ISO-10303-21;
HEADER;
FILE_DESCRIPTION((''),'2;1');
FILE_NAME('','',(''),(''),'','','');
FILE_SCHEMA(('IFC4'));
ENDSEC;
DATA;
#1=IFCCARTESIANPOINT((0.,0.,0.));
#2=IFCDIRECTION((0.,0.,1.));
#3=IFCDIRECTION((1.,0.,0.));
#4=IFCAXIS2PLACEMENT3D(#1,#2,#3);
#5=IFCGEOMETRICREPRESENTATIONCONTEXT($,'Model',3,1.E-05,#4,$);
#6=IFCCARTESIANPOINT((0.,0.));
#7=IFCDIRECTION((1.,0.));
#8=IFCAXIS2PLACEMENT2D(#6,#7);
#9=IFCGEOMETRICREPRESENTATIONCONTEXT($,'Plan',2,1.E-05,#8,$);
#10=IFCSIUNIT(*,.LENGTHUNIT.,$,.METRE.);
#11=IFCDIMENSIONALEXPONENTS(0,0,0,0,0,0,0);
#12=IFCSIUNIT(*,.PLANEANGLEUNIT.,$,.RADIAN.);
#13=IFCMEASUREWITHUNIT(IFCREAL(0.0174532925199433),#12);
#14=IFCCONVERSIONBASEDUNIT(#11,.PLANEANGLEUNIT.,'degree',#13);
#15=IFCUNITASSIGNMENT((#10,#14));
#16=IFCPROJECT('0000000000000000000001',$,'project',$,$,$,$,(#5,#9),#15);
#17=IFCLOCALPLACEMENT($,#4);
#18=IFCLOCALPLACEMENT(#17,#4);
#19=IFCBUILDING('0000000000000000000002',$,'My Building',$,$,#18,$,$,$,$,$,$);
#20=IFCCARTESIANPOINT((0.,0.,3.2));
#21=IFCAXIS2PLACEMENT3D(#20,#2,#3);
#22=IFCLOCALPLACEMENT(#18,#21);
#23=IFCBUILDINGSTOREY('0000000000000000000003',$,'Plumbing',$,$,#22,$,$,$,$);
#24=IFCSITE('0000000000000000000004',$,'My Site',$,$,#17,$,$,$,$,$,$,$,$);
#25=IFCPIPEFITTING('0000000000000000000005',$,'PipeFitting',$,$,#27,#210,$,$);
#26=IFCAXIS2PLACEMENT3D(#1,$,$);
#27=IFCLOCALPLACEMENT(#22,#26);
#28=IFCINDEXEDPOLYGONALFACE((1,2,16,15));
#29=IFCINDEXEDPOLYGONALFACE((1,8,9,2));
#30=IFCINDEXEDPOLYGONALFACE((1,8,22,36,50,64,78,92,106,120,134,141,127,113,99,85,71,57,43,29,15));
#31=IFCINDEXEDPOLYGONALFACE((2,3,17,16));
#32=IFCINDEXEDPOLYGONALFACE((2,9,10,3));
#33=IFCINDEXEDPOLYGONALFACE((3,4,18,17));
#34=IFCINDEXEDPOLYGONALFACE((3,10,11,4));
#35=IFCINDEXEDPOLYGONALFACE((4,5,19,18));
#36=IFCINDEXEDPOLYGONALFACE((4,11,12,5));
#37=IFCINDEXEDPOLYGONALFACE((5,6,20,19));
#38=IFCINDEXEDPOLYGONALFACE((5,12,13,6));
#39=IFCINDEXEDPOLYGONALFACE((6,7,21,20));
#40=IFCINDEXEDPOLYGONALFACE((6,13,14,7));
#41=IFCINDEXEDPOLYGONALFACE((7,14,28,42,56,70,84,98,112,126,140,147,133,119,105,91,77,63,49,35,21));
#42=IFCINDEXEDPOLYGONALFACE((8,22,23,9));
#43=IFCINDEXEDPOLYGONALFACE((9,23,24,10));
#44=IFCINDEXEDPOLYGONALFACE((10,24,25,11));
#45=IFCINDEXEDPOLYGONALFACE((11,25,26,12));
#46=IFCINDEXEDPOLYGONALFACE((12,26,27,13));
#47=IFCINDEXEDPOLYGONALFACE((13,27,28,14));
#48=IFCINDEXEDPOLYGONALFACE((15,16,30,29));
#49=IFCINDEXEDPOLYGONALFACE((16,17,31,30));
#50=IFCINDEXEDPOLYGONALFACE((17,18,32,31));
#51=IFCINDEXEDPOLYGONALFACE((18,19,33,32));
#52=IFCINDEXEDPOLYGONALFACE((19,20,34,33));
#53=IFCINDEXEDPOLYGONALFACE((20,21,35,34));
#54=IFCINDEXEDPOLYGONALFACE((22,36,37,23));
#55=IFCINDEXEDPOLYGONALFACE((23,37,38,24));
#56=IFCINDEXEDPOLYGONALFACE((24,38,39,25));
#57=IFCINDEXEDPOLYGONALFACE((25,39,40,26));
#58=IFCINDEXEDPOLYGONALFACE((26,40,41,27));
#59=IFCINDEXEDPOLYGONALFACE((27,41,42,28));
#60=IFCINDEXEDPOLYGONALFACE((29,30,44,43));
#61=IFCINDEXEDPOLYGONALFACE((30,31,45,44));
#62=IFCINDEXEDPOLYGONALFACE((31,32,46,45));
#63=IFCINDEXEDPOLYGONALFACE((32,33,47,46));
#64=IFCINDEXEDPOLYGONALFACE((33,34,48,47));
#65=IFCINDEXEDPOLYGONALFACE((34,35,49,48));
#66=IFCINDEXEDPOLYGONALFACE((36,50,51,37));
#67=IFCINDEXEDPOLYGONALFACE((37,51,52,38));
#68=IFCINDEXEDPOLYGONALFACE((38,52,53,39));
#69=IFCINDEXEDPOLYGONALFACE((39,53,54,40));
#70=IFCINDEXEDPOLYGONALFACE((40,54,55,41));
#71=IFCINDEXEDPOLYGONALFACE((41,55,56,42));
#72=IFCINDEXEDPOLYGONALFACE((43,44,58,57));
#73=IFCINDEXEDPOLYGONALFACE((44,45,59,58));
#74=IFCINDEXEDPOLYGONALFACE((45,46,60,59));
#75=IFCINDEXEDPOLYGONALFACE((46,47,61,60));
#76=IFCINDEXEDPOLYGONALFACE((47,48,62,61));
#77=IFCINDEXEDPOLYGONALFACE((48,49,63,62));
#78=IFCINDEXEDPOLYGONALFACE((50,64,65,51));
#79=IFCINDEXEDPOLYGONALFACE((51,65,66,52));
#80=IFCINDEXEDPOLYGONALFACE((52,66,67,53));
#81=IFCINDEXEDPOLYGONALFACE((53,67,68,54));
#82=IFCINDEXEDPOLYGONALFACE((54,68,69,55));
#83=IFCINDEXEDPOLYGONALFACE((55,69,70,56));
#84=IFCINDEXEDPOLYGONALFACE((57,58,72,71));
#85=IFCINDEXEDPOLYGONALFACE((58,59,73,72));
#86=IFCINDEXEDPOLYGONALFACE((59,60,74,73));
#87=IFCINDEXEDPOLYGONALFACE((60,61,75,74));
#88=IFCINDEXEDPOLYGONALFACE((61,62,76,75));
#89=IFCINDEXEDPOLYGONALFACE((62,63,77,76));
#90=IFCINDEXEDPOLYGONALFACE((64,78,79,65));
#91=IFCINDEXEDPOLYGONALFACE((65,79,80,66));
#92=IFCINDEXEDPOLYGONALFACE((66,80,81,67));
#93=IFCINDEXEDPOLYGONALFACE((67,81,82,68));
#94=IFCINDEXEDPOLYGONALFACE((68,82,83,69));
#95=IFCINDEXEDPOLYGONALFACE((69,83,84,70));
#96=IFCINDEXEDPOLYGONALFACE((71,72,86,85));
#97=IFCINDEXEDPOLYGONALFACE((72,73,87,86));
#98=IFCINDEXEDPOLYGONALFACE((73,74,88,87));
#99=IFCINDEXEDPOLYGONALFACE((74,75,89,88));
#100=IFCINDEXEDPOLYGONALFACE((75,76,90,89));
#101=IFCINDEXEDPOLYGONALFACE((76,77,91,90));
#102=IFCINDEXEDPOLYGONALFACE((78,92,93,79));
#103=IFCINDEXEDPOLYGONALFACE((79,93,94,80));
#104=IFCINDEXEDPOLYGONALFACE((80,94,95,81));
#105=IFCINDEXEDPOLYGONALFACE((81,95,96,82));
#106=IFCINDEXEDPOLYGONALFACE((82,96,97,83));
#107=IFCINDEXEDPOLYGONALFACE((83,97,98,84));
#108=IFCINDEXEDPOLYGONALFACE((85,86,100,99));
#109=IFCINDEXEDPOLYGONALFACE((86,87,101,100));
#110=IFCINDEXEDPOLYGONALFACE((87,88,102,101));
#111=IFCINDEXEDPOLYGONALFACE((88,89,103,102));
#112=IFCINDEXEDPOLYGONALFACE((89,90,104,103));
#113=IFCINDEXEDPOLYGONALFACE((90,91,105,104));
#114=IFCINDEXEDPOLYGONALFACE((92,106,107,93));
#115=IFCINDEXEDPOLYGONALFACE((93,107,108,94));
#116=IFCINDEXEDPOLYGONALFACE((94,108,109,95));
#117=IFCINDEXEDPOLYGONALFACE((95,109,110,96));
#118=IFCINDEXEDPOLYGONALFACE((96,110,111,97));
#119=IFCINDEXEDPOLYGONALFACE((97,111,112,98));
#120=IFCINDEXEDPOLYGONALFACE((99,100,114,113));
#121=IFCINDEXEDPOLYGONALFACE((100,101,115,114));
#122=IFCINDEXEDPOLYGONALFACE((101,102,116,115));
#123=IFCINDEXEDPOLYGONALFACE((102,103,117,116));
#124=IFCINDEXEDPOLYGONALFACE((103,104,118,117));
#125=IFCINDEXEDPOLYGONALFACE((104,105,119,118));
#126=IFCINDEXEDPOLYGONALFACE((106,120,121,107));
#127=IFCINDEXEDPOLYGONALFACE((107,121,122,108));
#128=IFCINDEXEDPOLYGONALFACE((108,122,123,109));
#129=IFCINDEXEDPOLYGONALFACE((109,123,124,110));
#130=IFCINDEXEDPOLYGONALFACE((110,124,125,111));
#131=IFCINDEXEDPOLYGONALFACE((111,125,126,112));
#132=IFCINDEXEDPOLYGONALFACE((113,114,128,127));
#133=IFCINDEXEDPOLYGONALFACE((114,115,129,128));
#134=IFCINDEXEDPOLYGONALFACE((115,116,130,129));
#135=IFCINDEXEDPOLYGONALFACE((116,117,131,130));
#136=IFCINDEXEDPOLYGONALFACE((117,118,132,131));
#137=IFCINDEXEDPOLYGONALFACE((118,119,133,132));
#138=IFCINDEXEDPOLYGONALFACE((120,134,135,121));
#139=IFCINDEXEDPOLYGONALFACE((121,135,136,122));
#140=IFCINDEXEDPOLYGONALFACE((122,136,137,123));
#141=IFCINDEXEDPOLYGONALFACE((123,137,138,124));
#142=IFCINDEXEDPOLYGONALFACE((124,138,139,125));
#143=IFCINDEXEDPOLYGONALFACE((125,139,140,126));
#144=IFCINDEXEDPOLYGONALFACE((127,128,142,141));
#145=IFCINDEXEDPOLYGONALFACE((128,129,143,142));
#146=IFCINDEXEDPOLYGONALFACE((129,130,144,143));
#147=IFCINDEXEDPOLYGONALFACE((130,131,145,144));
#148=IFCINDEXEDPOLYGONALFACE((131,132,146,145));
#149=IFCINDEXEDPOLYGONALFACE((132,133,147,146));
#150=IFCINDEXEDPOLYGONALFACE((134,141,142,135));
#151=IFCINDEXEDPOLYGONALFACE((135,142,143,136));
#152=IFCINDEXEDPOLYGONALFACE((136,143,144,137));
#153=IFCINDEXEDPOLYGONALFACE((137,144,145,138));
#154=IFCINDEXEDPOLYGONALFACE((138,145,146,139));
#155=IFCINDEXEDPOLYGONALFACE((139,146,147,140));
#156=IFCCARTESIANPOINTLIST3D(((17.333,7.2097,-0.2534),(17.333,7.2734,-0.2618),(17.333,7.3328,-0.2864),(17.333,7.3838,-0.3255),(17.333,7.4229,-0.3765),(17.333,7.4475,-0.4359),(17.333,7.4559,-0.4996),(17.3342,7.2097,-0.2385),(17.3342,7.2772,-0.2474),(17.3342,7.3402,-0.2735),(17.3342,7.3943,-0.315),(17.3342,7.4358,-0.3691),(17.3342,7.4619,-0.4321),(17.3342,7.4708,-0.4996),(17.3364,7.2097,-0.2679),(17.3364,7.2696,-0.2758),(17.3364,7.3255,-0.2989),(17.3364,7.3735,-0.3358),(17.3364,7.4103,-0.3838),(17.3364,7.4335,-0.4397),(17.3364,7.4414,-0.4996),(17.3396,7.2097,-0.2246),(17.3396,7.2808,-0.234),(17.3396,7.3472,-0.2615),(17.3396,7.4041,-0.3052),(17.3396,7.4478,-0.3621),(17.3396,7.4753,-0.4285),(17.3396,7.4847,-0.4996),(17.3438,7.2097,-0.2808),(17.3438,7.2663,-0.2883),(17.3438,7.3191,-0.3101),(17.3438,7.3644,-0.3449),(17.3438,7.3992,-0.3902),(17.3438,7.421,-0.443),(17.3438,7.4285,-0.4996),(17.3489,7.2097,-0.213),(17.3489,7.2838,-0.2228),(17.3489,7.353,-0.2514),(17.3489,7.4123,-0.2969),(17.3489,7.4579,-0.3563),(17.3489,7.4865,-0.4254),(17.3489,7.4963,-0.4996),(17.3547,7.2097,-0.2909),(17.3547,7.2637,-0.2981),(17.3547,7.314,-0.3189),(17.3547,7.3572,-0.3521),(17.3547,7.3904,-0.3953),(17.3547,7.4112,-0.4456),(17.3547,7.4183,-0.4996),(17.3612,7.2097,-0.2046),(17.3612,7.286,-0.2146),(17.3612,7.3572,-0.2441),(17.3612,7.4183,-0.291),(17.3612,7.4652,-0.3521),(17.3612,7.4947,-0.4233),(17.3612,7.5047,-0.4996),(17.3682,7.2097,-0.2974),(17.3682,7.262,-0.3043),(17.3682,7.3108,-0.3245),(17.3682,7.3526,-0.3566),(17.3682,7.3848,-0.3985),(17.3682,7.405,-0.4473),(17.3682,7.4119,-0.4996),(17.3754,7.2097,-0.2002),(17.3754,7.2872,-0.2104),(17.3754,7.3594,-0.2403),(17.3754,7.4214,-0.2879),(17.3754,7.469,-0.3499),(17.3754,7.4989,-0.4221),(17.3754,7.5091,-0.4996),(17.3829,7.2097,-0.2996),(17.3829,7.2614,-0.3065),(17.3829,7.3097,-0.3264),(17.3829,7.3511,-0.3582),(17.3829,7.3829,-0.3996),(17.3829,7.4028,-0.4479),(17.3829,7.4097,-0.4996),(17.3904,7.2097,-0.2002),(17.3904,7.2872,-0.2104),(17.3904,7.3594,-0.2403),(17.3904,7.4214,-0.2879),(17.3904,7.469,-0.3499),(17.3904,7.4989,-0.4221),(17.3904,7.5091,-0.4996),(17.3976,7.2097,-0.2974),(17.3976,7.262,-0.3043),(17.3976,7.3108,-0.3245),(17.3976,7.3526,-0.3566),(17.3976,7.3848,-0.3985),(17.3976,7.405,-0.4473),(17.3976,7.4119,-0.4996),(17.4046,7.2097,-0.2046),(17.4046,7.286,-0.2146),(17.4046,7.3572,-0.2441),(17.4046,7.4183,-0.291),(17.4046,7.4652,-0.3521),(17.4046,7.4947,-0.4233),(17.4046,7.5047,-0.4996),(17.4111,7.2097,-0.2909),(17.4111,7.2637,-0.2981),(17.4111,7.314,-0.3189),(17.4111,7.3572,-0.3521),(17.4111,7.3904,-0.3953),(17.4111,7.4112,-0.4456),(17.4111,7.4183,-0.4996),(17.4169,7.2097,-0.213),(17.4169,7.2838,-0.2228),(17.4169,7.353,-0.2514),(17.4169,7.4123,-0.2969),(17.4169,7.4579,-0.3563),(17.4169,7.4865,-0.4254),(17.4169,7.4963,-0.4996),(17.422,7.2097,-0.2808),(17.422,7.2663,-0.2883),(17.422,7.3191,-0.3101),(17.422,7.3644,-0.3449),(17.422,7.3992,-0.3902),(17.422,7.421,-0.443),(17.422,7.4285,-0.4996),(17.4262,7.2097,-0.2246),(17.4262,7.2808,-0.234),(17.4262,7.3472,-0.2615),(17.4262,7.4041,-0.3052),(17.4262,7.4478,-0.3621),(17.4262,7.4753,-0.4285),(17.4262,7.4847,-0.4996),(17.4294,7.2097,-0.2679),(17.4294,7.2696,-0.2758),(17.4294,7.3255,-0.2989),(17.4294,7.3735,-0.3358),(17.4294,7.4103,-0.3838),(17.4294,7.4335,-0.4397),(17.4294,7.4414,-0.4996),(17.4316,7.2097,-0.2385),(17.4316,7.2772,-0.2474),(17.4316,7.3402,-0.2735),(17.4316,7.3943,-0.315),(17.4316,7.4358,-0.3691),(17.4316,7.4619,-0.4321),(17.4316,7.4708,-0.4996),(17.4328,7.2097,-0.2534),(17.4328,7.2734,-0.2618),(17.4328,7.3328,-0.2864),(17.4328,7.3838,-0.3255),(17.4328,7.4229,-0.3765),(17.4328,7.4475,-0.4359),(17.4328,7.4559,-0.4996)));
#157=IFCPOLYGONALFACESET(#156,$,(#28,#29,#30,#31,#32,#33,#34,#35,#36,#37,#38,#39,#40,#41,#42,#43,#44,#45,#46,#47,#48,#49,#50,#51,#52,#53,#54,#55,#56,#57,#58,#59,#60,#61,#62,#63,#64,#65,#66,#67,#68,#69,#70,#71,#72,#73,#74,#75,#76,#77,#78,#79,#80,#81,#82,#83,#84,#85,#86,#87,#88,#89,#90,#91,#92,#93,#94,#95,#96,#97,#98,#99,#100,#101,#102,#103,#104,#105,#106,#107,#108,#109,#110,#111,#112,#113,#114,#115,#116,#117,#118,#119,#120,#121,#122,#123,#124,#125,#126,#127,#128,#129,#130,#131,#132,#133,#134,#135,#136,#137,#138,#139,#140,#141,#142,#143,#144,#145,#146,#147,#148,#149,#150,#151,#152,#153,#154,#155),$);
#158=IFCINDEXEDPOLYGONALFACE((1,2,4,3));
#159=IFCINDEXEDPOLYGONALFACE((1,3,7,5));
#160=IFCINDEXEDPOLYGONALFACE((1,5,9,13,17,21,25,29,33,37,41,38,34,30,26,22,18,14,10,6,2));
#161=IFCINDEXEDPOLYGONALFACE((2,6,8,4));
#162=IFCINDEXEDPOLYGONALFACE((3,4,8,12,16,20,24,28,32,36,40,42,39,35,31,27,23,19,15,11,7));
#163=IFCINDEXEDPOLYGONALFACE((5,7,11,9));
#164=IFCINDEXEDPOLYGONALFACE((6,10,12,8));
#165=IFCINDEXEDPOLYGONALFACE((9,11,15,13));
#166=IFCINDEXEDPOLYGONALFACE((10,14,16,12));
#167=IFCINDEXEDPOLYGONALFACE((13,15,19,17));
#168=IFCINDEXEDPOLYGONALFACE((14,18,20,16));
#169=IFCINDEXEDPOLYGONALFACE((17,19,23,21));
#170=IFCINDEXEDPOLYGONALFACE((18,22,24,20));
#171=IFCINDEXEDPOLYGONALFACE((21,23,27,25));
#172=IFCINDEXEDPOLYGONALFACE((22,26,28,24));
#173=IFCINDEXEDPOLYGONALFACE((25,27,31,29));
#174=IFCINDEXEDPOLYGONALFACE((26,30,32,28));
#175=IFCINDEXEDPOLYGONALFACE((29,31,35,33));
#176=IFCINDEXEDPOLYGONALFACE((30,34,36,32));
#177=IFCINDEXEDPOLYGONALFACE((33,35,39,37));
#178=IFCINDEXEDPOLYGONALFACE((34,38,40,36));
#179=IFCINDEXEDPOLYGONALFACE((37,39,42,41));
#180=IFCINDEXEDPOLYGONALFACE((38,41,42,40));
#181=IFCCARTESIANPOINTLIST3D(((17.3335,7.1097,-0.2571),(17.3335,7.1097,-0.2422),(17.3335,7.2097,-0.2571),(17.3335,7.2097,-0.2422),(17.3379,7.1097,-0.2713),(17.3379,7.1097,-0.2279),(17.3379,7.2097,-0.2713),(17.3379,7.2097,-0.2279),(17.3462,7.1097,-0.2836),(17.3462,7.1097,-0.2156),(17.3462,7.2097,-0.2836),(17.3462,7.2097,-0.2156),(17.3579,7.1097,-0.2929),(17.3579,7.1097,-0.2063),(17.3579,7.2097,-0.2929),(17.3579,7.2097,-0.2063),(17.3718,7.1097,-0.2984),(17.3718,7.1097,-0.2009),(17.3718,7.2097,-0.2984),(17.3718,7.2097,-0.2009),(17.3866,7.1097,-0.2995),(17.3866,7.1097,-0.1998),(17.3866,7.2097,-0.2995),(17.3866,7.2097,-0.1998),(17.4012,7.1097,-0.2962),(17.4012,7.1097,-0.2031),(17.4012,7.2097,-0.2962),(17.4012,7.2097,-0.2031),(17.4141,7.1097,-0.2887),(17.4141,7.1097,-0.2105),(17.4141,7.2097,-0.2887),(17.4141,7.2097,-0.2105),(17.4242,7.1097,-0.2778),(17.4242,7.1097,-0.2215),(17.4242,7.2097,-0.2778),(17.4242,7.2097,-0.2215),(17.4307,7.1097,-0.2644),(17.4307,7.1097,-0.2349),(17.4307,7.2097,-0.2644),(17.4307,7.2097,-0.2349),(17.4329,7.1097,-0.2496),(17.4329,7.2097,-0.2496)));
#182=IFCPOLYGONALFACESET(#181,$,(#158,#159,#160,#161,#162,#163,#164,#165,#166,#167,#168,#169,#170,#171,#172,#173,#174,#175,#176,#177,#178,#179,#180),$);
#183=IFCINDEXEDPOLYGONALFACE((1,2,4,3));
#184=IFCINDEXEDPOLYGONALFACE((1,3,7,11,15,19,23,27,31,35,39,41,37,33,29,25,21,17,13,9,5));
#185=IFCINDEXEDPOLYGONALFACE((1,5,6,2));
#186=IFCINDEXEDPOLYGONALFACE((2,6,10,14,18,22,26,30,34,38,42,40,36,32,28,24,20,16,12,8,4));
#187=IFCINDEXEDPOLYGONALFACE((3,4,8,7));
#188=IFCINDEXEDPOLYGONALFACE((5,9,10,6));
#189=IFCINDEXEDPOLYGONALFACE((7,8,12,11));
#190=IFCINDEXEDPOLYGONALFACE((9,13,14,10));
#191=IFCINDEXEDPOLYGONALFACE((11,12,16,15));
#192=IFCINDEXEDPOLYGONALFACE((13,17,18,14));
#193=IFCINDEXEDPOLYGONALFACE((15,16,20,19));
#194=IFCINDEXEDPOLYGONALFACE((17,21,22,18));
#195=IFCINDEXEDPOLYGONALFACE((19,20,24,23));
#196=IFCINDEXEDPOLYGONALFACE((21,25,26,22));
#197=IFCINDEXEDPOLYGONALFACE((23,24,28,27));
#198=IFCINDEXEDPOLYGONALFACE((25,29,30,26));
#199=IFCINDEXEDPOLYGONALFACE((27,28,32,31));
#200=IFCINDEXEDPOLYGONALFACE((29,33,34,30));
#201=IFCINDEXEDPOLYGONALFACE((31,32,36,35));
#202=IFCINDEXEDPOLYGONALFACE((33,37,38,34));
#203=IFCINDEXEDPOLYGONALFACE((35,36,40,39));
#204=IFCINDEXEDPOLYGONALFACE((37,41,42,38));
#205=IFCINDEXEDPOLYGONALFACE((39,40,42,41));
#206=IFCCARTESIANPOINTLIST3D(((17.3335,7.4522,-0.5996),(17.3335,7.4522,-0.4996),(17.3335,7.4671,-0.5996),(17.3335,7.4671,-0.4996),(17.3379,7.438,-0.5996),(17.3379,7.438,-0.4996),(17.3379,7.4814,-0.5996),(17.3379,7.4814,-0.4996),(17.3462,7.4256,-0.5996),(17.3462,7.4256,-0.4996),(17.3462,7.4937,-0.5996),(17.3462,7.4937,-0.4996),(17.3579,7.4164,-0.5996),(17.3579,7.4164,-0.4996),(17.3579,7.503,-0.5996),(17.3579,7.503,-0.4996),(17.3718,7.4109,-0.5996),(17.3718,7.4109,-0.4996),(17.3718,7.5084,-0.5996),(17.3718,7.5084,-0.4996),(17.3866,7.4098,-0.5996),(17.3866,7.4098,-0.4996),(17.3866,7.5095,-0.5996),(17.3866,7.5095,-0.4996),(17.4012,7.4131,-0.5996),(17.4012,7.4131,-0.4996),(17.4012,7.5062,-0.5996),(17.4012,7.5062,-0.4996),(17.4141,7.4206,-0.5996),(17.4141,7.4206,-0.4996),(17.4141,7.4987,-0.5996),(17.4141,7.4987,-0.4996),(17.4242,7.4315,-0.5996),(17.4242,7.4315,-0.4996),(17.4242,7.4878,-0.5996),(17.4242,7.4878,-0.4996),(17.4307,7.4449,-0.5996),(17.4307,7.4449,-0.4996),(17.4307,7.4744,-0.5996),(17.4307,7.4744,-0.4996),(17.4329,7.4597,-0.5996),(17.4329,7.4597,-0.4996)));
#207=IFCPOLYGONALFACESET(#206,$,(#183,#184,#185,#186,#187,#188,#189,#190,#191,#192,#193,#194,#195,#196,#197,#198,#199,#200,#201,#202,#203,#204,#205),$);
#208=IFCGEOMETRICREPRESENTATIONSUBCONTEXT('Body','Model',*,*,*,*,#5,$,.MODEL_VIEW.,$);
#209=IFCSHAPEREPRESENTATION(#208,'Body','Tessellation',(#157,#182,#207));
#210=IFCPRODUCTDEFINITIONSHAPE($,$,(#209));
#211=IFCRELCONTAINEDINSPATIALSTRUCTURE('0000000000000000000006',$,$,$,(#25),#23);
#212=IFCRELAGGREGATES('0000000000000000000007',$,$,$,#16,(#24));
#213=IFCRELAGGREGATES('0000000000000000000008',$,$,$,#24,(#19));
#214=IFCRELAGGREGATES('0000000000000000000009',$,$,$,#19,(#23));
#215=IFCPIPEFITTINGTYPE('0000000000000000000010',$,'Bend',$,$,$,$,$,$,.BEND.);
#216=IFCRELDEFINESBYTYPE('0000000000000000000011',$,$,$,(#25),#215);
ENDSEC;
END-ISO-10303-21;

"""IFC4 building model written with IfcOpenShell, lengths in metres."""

from ifc_helpers import new_model, entity, si_unit, converted_unit, frame, origin_with_axes, origin_2d_with_axis, place, context, subcontext, project, spatial, circle, extrude, source, transform, mapped, type_object, type_shapes, element, save


model = new_model("IFC4")

# Units and contexts
model_context = context("Model", 3, precision=1e-05, world=origin_with_axes())
plan_context = context("Plan", 2, precision=1e-05, world=origin_2d_with_axis())
body_context = subcontext(model_context, "Body", "Model", "MODEL_VIEW")
ifc_project = project(units=[si_unit("LENGTHUNIT", "METRE"), converted_unit("PLANEANGLEUNIT", "degree", entity("IfcReal", 0.0174532925199433), si_unit("PLANEANGLEUNIT", "RADIAN"), dimensions=[0, 0, 0, 0, 0, 0, 0])], contexts=[model_context, plan_context])

# Site, building, storey
site_placement = place(None, origin_with_axes())
site = spatial("IfcSite", under=ifc_project, at=site_placement, Name="My Site")
building_placement = place(site_placement, origin_with_axes())
building = spatial("IfcBuilding", under=site, at=building_placement, Name="My Building")
storey_placement = place(building_placement, frame((0.0, 0.0, 3.2), z_axis=(0.0, 0.0, 1.0), x_axis=(1.0, 0.0, 0.0)))
storey = spatial("IfcBuildingStorey", under=building, at=storey_placement, Name="Plumbing")

# Pipe fitting
pipe_fitting_type = type_object("IfcPipeFittingType", Name="Bend", PredefinedType="BEND")
shared_shape = source(origin_with_axes(), body_context, "Body", "SolidModel", [
    entity("IfcSweptDiskSolid", entity("IfcIndexedPolyCurve", entity("IfcCartesianPointList3D", [[0.0, 0.0, -0.1], [0.0, -0.0732, -0.2768], [0.0, -0.25, -0.35]]), [entity("IfcArcIndex", [1, 2, 3])]), 0.05),
    extrude(circle(Radius=0.05), origin_with_axes(), (0.0, 0.0, -1.0), 0.1),
    extrude(circle(Radius=0.05), frame((0.0, -0.25, -0.35), z_axis=(0.0, -1.0, 0.0), x_axis=(1.0, 0.0, 0.0)), (0.0, 0.0, 1.0), 0.1),
])
type_shapes(pipe_fitting_type, [shared_shape])
for number, where, z_axis, x_axis, name in (
    (1, (17.3829, 7.1097, -0.2496), (0.0, -1.0, 0.0), (1.0, 0.0, 0.0), "PipeFitting"),
):
    element("IfcPipeFitting", number, at=place(storey_placement, frame(where, z_axis=z_axis, x_axis=x_axis)), inside=storey, type_object=pipe_fitting_type, Name=name, context=body_context, shape_type="MappedRepresentation", body=[
        mapped(shared_shape, transform((0.0, 0.0, 0.0), x_axis=(1.0, 0.0, 0.0), y_axis=(0.0, 1.0, 0.0), z_axis=(0.0, 0.0, 1.0), scale=1.0)),
    ])

save(model, "model.ifc")
